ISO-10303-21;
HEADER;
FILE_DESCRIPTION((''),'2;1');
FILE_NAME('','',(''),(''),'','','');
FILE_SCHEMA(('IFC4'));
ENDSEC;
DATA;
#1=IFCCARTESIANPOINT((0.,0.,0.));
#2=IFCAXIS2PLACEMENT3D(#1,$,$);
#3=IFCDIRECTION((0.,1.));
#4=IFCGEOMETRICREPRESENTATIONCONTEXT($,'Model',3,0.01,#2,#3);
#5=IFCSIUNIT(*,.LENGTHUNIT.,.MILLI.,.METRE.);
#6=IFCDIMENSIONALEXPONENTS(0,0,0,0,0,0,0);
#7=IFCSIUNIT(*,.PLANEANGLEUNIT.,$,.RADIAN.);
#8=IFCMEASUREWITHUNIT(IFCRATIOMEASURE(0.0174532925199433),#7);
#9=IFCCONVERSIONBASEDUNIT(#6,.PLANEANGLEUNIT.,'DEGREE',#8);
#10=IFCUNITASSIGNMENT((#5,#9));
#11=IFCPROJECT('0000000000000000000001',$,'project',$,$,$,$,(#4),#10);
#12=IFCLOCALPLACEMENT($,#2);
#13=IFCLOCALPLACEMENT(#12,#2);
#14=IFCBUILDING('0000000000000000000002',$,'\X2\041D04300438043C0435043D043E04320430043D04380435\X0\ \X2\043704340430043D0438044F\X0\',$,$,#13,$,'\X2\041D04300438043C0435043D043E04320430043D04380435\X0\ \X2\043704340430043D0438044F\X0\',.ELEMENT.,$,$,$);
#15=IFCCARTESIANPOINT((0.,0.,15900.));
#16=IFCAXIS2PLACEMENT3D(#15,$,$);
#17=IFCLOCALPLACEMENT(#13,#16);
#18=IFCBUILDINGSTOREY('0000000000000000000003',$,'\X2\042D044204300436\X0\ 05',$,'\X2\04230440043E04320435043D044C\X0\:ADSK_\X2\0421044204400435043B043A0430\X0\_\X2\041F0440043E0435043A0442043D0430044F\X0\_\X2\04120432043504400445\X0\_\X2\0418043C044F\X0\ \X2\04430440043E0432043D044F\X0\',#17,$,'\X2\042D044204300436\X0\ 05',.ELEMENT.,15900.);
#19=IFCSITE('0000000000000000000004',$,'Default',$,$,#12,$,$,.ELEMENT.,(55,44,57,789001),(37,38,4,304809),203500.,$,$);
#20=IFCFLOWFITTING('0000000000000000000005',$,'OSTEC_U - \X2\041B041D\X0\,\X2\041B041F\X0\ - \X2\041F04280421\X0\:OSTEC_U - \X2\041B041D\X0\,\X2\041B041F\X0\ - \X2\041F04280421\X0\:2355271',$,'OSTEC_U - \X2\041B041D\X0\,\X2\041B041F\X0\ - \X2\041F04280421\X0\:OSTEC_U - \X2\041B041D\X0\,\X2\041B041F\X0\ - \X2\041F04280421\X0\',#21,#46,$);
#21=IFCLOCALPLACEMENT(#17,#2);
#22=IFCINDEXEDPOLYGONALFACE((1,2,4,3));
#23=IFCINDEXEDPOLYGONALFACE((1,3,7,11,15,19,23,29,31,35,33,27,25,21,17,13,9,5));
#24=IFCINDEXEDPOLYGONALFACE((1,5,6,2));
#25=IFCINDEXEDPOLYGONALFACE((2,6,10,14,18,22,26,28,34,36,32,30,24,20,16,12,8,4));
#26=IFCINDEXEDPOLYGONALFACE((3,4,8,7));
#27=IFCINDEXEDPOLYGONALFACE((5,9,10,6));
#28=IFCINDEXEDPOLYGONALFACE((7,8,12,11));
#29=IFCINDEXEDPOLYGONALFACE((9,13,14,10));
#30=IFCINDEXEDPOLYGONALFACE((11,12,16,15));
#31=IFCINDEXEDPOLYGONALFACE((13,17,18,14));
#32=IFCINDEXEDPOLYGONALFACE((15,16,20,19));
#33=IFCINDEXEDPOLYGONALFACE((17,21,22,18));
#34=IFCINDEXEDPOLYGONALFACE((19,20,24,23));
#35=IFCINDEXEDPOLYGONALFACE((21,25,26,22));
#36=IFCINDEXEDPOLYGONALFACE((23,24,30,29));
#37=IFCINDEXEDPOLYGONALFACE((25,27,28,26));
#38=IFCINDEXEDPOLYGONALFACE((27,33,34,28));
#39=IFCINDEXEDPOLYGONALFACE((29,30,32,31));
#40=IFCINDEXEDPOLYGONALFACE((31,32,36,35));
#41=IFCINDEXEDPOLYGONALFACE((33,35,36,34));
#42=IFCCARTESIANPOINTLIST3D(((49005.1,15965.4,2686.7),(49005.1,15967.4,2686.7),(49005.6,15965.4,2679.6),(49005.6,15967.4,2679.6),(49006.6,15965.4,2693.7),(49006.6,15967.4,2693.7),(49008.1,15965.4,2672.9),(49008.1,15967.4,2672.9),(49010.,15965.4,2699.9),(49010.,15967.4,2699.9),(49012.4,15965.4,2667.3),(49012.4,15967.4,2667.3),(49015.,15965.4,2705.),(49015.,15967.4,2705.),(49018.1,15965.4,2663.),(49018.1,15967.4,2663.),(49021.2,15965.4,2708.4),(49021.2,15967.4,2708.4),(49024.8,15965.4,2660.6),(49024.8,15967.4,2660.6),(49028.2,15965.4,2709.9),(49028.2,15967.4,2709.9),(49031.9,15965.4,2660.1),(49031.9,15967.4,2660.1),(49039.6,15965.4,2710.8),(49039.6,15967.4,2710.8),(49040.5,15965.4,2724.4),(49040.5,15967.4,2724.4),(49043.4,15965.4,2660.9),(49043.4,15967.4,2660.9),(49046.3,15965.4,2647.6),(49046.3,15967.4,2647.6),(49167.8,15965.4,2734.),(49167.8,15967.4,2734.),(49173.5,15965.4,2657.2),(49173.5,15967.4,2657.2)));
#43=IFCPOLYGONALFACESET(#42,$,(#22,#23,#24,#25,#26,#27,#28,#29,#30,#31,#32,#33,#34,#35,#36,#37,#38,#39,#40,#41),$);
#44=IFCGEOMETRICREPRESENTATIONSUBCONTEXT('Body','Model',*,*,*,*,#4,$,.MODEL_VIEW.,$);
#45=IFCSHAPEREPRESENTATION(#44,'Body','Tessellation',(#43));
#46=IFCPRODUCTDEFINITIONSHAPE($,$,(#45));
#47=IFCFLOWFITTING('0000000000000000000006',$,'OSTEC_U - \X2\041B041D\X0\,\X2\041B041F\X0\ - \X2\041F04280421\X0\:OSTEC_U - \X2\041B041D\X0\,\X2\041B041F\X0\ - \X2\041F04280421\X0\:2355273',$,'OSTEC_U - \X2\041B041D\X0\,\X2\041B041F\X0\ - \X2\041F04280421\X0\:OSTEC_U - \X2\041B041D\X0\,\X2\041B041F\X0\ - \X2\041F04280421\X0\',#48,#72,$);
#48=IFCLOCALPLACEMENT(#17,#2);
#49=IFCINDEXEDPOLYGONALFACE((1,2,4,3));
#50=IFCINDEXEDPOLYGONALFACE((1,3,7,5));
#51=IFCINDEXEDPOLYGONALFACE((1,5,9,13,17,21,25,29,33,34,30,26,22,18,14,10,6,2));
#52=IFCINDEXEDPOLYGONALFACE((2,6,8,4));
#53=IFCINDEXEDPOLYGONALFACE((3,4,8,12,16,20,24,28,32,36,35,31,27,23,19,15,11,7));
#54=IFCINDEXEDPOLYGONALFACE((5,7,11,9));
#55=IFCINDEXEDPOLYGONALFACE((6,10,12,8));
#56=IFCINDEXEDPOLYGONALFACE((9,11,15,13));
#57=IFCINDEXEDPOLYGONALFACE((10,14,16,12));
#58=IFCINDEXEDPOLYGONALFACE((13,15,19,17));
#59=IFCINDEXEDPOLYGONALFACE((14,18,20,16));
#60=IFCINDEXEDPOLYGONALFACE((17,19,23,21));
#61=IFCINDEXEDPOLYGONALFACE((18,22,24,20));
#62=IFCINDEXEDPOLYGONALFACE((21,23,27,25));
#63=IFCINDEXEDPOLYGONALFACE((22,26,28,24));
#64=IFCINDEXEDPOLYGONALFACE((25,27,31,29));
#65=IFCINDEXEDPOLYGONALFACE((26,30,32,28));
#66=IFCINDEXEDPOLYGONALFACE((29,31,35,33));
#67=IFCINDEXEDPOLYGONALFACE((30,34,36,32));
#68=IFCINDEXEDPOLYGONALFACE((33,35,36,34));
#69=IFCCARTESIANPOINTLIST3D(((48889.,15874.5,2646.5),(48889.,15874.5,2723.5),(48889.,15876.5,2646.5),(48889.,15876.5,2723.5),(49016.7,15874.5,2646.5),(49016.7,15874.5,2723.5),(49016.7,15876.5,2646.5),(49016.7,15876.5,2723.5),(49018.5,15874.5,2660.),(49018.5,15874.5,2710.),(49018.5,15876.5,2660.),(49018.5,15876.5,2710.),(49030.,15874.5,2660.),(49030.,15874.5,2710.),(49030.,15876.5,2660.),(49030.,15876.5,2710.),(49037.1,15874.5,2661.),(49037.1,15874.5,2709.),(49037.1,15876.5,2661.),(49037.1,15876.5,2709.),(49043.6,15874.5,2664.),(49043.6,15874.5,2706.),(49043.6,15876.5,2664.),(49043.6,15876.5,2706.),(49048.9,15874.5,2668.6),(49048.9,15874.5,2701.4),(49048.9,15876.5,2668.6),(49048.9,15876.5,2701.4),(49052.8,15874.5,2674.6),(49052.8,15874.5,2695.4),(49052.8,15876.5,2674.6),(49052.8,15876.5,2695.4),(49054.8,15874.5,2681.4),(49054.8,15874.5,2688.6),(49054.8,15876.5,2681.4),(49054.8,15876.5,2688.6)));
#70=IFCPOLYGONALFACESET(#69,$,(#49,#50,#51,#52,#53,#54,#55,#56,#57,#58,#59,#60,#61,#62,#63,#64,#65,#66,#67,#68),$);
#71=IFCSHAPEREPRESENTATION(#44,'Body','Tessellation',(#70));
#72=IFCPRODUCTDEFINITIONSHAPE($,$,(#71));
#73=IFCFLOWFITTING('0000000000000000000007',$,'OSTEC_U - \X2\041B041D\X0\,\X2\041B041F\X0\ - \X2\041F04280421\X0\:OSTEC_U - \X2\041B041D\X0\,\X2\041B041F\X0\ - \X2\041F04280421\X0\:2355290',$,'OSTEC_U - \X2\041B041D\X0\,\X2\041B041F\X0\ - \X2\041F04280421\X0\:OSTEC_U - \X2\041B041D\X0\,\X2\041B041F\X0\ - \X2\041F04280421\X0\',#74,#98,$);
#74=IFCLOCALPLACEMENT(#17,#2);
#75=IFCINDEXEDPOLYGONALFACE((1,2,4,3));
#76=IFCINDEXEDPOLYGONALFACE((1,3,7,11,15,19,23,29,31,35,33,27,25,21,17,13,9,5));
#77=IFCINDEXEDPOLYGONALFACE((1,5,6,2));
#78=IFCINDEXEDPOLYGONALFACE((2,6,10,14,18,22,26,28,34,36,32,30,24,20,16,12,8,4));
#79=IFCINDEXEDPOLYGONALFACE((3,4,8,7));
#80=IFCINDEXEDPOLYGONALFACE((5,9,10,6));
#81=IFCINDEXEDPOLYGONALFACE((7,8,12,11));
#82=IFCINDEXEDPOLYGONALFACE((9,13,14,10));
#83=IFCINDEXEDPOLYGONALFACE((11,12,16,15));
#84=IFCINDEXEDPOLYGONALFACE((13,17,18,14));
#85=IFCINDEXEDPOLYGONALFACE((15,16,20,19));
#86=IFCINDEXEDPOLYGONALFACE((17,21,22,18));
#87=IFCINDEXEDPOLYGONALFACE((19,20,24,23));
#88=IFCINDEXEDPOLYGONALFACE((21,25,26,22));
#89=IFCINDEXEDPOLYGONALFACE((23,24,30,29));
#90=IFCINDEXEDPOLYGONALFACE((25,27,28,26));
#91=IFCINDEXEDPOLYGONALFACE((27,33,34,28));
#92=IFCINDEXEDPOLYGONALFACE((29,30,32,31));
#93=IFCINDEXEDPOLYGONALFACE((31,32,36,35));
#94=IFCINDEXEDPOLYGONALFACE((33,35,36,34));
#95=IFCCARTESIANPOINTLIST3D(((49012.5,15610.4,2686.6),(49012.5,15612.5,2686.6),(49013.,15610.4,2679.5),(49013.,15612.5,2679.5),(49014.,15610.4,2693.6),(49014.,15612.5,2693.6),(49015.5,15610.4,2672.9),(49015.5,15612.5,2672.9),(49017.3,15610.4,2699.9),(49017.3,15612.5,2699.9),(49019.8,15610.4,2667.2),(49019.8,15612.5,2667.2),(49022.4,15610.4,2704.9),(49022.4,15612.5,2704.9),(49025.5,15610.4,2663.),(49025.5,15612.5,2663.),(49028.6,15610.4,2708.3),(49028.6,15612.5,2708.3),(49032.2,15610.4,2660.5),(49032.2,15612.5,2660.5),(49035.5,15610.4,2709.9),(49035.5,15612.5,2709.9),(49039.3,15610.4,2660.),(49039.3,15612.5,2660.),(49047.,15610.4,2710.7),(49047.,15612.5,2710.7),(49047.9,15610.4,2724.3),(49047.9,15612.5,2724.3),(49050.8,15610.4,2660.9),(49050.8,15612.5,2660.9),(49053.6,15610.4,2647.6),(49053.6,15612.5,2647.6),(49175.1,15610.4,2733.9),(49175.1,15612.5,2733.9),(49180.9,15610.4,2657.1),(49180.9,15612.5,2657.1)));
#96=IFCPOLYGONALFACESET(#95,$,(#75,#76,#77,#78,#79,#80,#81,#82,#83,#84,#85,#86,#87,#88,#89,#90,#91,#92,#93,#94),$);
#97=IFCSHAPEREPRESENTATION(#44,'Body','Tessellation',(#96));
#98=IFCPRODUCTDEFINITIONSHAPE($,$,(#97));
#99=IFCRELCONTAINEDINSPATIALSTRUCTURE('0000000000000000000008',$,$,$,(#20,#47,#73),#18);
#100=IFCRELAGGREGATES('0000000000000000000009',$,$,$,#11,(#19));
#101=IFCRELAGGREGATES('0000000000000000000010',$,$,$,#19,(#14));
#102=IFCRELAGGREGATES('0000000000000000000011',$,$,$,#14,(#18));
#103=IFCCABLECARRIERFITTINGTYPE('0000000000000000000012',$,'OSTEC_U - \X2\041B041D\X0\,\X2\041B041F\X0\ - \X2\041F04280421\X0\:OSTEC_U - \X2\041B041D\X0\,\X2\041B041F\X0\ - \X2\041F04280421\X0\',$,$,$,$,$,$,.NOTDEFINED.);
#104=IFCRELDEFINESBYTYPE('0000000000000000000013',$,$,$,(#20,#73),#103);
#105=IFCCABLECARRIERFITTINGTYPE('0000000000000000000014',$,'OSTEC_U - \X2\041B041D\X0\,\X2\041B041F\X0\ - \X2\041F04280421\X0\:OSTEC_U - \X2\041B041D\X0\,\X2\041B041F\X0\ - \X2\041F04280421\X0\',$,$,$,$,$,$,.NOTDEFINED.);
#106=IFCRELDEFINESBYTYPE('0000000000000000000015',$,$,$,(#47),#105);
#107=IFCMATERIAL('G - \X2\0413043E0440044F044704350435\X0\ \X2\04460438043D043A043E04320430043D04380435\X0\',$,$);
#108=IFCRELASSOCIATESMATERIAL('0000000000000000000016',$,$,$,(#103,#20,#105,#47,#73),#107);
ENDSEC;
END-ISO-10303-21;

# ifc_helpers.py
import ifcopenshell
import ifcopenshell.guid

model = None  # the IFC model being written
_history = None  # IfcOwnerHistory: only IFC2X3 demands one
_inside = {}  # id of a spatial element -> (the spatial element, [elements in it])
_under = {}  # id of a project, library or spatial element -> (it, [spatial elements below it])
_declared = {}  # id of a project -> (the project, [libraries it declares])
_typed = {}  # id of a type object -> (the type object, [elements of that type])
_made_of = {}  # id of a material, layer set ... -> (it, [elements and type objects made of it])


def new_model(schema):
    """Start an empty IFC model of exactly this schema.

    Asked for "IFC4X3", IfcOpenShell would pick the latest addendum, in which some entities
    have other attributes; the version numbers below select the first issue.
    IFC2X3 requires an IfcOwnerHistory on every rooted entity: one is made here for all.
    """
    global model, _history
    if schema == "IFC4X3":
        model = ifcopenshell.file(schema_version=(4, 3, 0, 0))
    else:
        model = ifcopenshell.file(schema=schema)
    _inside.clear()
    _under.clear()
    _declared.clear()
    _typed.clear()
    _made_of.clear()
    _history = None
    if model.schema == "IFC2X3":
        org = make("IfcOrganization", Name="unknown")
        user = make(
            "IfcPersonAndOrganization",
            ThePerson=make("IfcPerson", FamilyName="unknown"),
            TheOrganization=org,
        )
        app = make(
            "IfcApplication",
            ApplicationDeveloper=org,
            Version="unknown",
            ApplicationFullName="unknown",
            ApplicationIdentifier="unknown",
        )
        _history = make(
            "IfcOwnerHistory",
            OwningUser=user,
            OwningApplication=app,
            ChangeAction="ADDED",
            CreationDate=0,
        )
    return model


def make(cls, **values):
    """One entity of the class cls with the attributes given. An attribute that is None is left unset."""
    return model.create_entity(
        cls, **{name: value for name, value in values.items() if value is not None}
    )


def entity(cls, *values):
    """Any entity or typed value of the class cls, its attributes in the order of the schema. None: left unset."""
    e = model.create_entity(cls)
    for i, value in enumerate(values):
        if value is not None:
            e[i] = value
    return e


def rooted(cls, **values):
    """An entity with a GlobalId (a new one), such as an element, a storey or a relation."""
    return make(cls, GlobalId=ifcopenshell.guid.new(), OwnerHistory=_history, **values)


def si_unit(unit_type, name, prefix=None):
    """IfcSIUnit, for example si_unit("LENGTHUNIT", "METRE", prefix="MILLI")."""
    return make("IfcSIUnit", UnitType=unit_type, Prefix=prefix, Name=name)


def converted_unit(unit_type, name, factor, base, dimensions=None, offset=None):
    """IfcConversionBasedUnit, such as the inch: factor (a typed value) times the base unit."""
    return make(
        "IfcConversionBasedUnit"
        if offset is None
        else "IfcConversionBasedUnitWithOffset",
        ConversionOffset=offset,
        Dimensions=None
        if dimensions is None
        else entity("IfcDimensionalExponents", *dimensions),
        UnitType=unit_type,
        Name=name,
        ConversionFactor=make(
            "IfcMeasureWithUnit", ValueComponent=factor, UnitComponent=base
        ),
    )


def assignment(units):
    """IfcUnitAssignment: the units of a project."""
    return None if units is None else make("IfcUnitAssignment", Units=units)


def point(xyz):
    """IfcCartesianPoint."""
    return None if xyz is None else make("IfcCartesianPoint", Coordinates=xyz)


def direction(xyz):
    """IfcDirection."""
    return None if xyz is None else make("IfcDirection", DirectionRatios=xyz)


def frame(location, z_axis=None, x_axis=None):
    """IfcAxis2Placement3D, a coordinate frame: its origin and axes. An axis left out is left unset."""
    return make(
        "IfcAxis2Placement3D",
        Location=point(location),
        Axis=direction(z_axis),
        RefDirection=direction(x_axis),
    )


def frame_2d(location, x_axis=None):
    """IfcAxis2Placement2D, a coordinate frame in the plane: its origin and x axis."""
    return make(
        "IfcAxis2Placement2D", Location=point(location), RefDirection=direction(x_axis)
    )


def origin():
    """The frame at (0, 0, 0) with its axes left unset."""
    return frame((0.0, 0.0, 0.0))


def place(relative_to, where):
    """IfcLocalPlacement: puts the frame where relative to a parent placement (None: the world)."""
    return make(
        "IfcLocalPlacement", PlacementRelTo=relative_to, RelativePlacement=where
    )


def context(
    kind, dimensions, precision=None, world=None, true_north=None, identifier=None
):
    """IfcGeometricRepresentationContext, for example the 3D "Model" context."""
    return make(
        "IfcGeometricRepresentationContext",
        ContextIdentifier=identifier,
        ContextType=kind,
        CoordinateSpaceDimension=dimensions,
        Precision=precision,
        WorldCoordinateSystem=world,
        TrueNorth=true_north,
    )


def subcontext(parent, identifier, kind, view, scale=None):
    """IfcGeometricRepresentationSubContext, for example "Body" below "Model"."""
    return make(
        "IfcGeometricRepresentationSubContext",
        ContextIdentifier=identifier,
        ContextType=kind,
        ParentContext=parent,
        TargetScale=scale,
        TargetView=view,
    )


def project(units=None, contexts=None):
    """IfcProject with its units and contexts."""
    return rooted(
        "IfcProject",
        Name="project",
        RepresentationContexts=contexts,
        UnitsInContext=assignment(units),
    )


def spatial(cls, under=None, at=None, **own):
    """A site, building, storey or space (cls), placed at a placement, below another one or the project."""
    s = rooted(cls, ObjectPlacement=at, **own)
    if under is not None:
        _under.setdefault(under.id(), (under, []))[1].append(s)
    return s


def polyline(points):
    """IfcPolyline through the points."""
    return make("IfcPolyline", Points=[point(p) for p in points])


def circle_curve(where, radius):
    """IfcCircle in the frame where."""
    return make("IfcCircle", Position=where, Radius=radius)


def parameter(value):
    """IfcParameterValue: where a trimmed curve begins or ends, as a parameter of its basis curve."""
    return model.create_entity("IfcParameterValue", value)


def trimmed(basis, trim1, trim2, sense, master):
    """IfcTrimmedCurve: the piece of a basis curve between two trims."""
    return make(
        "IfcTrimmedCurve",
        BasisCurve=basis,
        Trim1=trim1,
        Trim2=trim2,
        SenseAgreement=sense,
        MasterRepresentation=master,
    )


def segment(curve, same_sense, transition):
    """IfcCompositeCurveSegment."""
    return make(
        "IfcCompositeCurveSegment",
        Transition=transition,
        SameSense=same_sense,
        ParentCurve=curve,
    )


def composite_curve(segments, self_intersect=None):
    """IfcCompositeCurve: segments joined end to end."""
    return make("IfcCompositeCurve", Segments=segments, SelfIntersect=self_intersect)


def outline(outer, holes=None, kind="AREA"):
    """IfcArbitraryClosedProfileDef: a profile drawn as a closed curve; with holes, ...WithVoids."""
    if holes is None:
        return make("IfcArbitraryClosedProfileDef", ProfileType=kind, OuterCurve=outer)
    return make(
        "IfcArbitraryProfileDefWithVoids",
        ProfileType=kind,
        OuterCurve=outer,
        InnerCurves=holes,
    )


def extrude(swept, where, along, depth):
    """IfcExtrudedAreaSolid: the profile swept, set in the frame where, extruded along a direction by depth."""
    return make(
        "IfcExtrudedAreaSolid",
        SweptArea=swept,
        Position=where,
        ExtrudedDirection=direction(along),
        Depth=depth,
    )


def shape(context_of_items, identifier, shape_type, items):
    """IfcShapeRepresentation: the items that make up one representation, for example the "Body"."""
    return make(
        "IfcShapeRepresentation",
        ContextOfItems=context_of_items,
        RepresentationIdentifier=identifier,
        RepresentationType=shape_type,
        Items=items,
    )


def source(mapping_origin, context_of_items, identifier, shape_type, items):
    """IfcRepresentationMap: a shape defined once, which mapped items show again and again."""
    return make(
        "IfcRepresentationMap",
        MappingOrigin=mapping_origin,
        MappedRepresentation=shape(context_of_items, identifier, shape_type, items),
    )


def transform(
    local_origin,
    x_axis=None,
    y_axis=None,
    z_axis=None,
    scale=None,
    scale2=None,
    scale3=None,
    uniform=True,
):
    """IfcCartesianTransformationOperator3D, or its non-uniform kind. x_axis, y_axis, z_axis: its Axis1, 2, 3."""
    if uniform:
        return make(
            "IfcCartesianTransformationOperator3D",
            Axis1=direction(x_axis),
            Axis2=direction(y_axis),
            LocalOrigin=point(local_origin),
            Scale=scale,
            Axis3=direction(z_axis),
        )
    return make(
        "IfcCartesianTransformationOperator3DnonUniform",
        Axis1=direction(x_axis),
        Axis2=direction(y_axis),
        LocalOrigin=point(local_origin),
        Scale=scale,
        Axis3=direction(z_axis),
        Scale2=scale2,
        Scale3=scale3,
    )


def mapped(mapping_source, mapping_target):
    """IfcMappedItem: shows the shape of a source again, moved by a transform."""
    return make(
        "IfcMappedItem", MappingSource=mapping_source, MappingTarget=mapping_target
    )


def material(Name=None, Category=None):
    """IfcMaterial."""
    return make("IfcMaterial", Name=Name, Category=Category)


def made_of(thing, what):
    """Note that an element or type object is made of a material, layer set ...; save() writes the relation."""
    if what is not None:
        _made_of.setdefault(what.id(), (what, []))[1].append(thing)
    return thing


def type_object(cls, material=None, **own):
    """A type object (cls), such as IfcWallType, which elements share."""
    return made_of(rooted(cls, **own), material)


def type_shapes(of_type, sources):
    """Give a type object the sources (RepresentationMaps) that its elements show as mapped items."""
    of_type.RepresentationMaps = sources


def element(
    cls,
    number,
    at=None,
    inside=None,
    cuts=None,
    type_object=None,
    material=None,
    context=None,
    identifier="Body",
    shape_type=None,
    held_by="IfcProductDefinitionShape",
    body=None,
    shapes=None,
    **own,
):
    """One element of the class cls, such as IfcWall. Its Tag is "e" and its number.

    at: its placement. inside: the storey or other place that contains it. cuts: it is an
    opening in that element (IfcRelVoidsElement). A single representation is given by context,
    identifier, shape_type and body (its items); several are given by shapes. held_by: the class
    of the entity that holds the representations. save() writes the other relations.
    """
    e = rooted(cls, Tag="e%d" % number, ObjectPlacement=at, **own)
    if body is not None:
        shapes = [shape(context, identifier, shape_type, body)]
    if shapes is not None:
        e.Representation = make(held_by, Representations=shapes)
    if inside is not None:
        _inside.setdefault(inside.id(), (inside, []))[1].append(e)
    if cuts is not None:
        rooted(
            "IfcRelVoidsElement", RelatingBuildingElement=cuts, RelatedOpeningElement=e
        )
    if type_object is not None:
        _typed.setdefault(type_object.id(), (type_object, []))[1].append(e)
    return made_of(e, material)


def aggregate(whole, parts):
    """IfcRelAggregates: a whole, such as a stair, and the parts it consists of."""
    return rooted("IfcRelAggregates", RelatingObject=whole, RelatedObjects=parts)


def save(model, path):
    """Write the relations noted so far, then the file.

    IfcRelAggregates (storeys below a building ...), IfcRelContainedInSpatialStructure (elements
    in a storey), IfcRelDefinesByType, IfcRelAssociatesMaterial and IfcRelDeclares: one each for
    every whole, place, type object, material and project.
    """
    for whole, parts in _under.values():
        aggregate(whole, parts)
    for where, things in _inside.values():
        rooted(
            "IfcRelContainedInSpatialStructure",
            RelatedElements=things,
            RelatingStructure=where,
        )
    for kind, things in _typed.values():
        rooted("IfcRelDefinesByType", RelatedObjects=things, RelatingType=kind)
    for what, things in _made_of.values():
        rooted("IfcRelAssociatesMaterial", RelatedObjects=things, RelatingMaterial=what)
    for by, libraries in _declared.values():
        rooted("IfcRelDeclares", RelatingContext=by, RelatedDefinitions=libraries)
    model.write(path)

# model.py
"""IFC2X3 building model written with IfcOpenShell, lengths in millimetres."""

from ifc_helpers import new_model, entity, si_unit, converted_unit, direction, frame, frame_2d, origin, place, context, subcontext, project, spatial, polyline, circle_curve, parameter, trimmed, segment, composite_curve, outline, extrude, source, transform, mapped, material, type_object, type_shapes, element, save


model = new_model("IFC2X3")

# Units and contexts
model_context = context("Model", 3, precision=0.01, world=origin(), true_north=direction((0.0, 1.0)))
body_context = subcontext(model_context, "Body", "Model", "MODEL_VIEW")
ifc_project = project(units=[si_unit("LENGTHUNIT", "METRE", prefix="MILLI"), converted_unit("PLANEANGLEUNIT", "DEGREE", entity("IfcRatioMeasure", 0.0174532925199433), si_unit("PLANEANGLEUNIT", "RADIAN"), dimensions=[0, 0, 0, 0, 0, 0, 0])], contexts=[model_context])

# Site, building, storey
site_placement = place(None, origin())
site = spatial("IfcSite", under=ifc_project, at=site_placement, Name="Default", CompositionType="ELEMENT", RefLatitude=(55, 44, 57, 789001), RefLongitude=(37, 38, 4, 304809), RefElevation=203500.0)
building_placement = place(site_placement, origin())
building = spatial("IfcBuilding", under=site, at=building_placement, Name="Наименование здания", LongName="Наименование здания", CompositionType="ELEMENT")
storey_placement = place(building_placement, frame((0.0, 0.0, 15900.0)))
storey = spatial("IfcBuildingStorey", under=building, at=storey_placement, Name="Этаж 05", ObjectType="Уровень:ADSK_Стрелка_Проектная_Вверх_Имя уровня", LongName="Этаж 05", CompositionType="ELEMENT", Elevation=15900.0)

# Flow fittings
ifc_material_1 = material(Name="G - Горячее цинкование")
cable_carrier_fitting_type_1 = type_object("IfcCableCarrierFittingType", Name="OSTEC_U - ЛН,ЛП - ПШС:OSTEC_U - ЛН,ЛП - ПШС", PredefinedType="NOTDEFINED", material=ifc_material_1)
shared_shape_1 = source(origin(), body_context, "Body", "SweptSolid", [
    extrude(outline(composite_curve([segment(trimmed(circle_curve(frame_2d((-41.5, 0.0), x_axis=(1.0, 0.0)), 25.0), [parameter(90.0)], [parameter(270.0)], True, "PARAMETER"), True, "CONTINUOUS"), segment(polyline([(-41.5, -25.0), (-30.0, -25.0)]), True, "CONTINUOUS"), segment(polyline([(-30.0, -25.0), (-28.1, -38.5)]), True, "CONTINUOUS"), segment(polyline([(-28.1, -38.5), (99.5, -38.5)]), True, "CONTINUOUS"), segment(polyline([(99.5, -38.5), (99.5, 38.5)]), True, "CONTINUOUS"), segment(polyline([(99.5, 38.5), (-28.1, 38.5)]), True, "CONTINUOUS"), segment(polyline([(-28.1, 38.5), (-30.0, 25.0)]), True, "CONTINUOUS"), segment(polyline([(-30.0, 25.0), (-41.5, 25.0)]), True, "CONTINUOUS")], self_intersect=False)), frame((41.5, 0.0, 0.0)), (0.0, 0.0, 1.0), 2.0),
])
type_shapes(cable_carrier_fitting_type_1, [shared_shape_1])
flow_fitting_1_placement = place(storey_placement, frame((49030.0, 15965.5, 2685.0), z_axis=(0.0, 1.0, 0.0), x_axis=(0.997186, 0.0, 0.074969)))
element("IfcFlowFitting", 1, at=flow_fitting_1_placement, inside=storey, type_object=cable_carrier_fitting_type_1, material=ifc_material_1, Name="OSTEC_U - ЛН,ЛП - ПШС:OSTEC_U - ЛН,ЛП - ПШС:2355271", ObjectType="OSTEC_U - ЛН,ЛП - ПШС:OSTEC_U - ЛН,ЛП - ПШС", context=body_context, shape_type="MappedRepresentation", body=[
    mapped(shared_shape_1, transform((0.0, 0.0, 0.0), scale=1.0)),
])
cable_carrier_fitting_type_2 = type_object("IfcCableCarrierFittingType", Name="OSTEC_U - ЛН,ЛП - ПШС:OSTEC_U - ЛН,ЛП - ПШС", PredefinedType="NOTDEFINED", material=ifc_material_1)
type_shapes(cable_carrier_fitting_type_2, [shared_shape_1])
flow_fitting_2_placement = place(storey_placement, frame((49030.0, 15876.5, 2685.0), z_axis=(0.0, -1.0, 0.0), x_axis=(-1.0, 0.0, 0.0)))
element("IfcFlowFitting", 2, at=flow_fitting_2_placement, inside=storey, type_object=cable_carrier_fitting_type_2, material=ifc_material_1, Name="OSTEC_U - ЛН,ЛП - ПШС:OSTEC_U - ЛН,ЛП - ПШС:2355273", ObjectType="OSTEC_U - ЛН,ЛП - ПШС:OSTEC_U - ЛН,ЛП - ПШС", context=body_context, shape_type="MappedRepresentation", body=[
    mapped(shared_shape_1, transform((0.0, 0.0, 0.0), scale=1.0)),
])
flow_fitting_3_placement = place(storey_placement, frame((49037.4, 15610.5, 2684.9), z_axis=(0.0, 1.0, 0.0), x_axis=(0.997183, 0.0, 0.075005)))
element("IfcFlowFitting", 3, at=flow_fitting_3_placement, inside=storey, type_object=cable_carrier_fitting_type_1, material=ifc_material_1, Name="OSTEC_U - ЛН,ЛП - ПШС:OSTEC_U - ЛН,ЛП - ПШС:2355290", ObjectType="OSTEC_U - ЛН,ЛП - ПШС:OSTEC_U - ЛН,ЛП - ПШС", context=body_context, shape_type="MappedRepresentation", body=[
    mapped(shared_shape_1, transform((0.0, 0.0, 0.0), scale=1.0)),
])

save(model, "model.ifc")
